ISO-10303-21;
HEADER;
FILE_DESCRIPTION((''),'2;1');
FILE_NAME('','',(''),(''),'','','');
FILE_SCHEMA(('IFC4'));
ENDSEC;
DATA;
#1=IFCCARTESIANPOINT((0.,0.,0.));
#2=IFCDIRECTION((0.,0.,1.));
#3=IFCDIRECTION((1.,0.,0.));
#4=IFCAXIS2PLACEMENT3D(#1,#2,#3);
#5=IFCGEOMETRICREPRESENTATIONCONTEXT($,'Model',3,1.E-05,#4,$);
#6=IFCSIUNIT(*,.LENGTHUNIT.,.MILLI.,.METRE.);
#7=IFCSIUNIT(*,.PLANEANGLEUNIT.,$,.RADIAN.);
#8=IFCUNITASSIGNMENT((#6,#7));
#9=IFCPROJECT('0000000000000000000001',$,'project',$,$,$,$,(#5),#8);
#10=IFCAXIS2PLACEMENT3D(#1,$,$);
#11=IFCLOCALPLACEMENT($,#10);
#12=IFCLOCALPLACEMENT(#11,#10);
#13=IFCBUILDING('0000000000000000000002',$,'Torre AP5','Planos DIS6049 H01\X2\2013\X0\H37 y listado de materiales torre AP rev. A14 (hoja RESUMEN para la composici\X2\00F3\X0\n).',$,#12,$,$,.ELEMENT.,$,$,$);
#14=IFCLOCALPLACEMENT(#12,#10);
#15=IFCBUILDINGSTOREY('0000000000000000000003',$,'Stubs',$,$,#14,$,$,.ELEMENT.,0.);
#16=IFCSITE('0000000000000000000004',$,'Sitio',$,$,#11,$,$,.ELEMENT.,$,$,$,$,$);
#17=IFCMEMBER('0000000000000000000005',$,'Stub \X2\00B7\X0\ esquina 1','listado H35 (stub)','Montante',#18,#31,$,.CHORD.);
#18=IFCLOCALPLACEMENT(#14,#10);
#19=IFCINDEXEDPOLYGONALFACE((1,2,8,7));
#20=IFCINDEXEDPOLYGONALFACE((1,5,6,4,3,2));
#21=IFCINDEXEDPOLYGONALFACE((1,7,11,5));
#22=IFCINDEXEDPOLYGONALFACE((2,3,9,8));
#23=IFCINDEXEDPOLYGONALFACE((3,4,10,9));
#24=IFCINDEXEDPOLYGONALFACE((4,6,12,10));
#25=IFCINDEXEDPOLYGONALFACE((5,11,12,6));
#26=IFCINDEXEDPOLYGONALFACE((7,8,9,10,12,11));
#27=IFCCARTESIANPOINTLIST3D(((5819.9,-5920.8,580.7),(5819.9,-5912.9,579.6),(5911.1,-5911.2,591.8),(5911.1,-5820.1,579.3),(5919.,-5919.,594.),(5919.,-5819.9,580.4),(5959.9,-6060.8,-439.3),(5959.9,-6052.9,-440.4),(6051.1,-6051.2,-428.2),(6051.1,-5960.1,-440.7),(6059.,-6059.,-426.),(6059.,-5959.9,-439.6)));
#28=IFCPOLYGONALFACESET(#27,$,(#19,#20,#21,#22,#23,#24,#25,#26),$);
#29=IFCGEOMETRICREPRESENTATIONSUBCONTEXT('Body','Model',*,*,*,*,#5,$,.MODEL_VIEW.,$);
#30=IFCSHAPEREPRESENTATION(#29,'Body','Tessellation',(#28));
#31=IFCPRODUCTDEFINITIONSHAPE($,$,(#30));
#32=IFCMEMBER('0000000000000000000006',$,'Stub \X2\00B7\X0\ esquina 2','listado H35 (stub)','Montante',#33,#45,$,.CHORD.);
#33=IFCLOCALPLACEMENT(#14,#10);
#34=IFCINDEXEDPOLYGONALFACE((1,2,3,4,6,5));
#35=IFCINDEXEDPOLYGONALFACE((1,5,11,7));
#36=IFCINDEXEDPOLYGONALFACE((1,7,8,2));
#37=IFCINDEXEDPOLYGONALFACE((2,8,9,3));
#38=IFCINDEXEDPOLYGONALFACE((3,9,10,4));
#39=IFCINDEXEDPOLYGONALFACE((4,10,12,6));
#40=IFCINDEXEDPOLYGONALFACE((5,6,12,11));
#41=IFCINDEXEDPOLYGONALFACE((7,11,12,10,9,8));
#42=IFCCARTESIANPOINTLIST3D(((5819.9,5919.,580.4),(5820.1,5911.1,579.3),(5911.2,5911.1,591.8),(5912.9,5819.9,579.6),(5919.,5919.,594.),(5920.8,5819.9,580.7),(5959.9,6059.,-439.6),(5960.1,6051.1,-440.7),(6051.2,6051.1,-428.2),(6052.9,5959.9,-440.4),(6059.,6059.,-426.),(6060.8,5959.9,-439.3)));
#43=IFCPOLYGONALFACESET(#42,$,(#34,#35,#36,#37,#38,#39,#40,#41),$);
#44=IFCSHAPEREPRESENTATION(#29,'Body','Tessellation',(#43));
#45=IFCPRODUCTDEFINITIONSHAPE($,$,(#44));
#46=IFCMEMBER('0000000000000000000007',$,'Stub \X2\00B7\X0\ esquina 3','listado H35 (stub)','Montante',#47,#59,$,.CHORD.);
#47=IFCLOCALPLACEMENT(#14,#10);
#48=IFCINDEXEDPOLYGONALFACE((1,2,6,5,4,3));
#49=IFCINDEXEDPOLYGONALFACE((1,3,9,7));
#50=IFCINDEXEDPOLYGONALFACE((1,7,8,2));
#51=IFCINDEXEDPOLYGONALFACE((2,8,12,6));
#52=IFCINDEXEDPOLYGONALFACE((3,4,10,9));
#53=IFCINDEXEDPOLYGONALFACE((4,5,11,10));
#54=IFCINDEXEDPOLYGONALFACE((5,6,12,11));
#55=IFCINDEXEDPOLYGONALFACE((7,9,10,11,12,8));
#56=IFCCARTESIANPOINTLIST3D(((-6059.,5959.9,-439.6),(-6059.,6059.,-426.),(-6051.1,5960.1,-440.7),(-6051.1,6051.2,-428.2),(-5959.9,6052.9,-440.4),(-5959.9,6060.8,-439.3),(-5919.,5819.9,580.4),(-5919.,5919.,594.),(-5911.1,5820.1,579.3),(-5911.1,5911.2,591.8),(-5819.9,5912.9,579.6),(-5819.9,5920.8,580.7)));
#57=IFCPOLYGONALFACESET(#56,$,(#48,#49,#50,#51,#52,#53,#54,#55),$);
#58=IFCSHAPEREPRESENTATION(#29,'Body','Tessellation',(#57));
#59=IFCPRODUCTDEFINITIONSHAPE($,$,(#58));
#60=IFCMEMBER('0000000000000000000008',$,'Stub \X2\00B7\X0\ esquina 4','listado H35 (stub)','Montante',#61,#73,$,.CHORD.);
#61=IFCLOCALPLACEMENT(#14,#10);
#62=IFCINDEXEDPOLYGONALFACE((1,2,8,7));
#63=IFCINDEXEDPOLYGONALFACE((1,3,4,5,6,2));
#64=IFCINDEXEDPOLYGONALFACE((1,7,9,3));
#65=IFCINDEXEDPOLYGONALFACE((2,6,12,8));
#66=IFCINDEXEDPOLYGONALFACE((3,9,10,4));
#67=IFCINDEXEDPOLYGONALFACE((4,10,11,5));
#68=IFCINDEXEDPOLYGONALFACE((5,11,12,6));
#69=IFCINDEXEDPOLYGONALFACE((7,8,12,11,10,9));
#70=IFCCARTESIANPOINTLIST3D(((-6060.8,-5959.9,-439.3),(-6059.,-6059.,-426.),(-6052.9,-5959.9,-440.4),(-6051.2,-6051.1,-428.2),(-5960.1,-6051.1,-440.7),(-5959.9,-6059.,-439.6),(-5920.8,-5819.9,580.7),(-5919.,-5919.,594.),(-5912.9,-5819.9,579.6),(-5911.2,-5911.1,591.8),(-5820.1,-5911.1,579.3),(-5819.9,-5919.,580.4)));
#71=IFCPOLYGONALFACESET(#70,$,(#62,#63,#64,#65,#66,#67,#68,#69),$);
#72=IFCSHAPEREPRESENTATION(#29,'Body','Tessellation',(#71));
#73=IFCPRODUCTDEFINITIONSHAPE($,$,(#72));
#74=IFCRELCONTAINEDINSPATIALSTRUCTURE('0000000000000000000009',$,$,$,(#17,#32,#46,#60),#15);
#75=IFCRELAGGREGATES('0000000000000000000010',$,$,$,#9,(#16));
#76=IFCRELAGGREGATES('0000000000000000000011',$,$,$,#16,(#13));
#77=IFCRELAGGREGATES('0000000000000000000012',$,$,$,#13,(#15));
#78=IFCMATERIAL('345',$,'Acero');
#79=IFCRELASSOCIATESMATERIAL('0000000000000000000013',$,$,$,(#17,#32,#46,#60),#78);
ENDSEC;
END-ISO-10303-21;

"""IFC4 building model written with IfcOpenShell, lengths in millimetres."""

from ifc_helpers import new_model, si_unit, frame, frame_2d, origin, origin_with_axes, place, context, subcontext, project, spatial, l_section, extrude, material, element, save


model = new_model("IFC4")

# Units and contexts
model_context = context("Model", 3, precision=1e-05, world=origin_with_axes())
body_context = subcontext(model_context, "Body", "Model", "MODEL_VIEW")
ifc_project = project(units=[si_unit("LENGTHUNIT", "METRE", prefix="MILLI"), si_unit("PLANEANGLEUNIT", "RADIAN")], contexts=[model_context])

# Site, building, storey
site_placement = place(None, origin())
site = spatial("IfcSite", under=ifc_project, at=site_placement, Name="Sitio", CompositionType="ELEMENT")
building_placement = place(site_placement, origin())
building = spatial("IfcBuilding", under=site, at=building_placement, Name="Torre AP5", Description="Planos DIS6049 H01–H37 y listado de materiales torre AP rev. A14 (hoja RESUMEN para la composición).", CompositionType="ELEMENT")
storey_placement = place(building_placement, origin())
storey = spatial("IfcBuildingStorey", under=building, at=storey_placement, Name="Stubs", CompositionType="ELEMENT", Elevation=0.0)

# Members
ifc_material = material(Name="345", Category="Acero")
for number, where, z_axis, x_axis, name in (
    (1, (5919.0, -5919.0, 594.0), (0.13474, -0.13474, -0.981677), (-0.990881, -0.018322, -0.133488), "Stub · esquina 1"),
    (2, (5919.0, 5919.0, 594.0), (0.13474, 0.13474, -0.981677), (0.018322, -0.990881, -0.133488), "Stub · esquina 2"),
    (3, (-5919.0, 5919.0, 594.0), (-0.13474, 0.13474, -0.981677), (0.990881, 0.018322, -0.133488), "Stub · esquina 3"),
    (4, (-5919.0, -5919.0, 594.0), (-0.13474, -0.13474, -0.981677), (-0.018322, 0.990881, -0.133488), "Stub · esquina 4"),
):
    element("IfcMember", number, at=place(storey_placement, frame(where, z_axis=z_axis, x_axis=x_axis)), inside=storey, material=ifc_material, Name=name, Description="listado H35 (stub)", ObjectType="Montante", PredefinedType="CHORD", context=body_context, shape_type="SweptSolid", body=[
        extrude(l_section(Depth=100.0, Width=100.0, Thickness=8.0, at=frame_2d((50.0, 50.0))), None, (0.0, 0.0, 1.0), 1039.0),
    ])

save(model, "model.ifc")
